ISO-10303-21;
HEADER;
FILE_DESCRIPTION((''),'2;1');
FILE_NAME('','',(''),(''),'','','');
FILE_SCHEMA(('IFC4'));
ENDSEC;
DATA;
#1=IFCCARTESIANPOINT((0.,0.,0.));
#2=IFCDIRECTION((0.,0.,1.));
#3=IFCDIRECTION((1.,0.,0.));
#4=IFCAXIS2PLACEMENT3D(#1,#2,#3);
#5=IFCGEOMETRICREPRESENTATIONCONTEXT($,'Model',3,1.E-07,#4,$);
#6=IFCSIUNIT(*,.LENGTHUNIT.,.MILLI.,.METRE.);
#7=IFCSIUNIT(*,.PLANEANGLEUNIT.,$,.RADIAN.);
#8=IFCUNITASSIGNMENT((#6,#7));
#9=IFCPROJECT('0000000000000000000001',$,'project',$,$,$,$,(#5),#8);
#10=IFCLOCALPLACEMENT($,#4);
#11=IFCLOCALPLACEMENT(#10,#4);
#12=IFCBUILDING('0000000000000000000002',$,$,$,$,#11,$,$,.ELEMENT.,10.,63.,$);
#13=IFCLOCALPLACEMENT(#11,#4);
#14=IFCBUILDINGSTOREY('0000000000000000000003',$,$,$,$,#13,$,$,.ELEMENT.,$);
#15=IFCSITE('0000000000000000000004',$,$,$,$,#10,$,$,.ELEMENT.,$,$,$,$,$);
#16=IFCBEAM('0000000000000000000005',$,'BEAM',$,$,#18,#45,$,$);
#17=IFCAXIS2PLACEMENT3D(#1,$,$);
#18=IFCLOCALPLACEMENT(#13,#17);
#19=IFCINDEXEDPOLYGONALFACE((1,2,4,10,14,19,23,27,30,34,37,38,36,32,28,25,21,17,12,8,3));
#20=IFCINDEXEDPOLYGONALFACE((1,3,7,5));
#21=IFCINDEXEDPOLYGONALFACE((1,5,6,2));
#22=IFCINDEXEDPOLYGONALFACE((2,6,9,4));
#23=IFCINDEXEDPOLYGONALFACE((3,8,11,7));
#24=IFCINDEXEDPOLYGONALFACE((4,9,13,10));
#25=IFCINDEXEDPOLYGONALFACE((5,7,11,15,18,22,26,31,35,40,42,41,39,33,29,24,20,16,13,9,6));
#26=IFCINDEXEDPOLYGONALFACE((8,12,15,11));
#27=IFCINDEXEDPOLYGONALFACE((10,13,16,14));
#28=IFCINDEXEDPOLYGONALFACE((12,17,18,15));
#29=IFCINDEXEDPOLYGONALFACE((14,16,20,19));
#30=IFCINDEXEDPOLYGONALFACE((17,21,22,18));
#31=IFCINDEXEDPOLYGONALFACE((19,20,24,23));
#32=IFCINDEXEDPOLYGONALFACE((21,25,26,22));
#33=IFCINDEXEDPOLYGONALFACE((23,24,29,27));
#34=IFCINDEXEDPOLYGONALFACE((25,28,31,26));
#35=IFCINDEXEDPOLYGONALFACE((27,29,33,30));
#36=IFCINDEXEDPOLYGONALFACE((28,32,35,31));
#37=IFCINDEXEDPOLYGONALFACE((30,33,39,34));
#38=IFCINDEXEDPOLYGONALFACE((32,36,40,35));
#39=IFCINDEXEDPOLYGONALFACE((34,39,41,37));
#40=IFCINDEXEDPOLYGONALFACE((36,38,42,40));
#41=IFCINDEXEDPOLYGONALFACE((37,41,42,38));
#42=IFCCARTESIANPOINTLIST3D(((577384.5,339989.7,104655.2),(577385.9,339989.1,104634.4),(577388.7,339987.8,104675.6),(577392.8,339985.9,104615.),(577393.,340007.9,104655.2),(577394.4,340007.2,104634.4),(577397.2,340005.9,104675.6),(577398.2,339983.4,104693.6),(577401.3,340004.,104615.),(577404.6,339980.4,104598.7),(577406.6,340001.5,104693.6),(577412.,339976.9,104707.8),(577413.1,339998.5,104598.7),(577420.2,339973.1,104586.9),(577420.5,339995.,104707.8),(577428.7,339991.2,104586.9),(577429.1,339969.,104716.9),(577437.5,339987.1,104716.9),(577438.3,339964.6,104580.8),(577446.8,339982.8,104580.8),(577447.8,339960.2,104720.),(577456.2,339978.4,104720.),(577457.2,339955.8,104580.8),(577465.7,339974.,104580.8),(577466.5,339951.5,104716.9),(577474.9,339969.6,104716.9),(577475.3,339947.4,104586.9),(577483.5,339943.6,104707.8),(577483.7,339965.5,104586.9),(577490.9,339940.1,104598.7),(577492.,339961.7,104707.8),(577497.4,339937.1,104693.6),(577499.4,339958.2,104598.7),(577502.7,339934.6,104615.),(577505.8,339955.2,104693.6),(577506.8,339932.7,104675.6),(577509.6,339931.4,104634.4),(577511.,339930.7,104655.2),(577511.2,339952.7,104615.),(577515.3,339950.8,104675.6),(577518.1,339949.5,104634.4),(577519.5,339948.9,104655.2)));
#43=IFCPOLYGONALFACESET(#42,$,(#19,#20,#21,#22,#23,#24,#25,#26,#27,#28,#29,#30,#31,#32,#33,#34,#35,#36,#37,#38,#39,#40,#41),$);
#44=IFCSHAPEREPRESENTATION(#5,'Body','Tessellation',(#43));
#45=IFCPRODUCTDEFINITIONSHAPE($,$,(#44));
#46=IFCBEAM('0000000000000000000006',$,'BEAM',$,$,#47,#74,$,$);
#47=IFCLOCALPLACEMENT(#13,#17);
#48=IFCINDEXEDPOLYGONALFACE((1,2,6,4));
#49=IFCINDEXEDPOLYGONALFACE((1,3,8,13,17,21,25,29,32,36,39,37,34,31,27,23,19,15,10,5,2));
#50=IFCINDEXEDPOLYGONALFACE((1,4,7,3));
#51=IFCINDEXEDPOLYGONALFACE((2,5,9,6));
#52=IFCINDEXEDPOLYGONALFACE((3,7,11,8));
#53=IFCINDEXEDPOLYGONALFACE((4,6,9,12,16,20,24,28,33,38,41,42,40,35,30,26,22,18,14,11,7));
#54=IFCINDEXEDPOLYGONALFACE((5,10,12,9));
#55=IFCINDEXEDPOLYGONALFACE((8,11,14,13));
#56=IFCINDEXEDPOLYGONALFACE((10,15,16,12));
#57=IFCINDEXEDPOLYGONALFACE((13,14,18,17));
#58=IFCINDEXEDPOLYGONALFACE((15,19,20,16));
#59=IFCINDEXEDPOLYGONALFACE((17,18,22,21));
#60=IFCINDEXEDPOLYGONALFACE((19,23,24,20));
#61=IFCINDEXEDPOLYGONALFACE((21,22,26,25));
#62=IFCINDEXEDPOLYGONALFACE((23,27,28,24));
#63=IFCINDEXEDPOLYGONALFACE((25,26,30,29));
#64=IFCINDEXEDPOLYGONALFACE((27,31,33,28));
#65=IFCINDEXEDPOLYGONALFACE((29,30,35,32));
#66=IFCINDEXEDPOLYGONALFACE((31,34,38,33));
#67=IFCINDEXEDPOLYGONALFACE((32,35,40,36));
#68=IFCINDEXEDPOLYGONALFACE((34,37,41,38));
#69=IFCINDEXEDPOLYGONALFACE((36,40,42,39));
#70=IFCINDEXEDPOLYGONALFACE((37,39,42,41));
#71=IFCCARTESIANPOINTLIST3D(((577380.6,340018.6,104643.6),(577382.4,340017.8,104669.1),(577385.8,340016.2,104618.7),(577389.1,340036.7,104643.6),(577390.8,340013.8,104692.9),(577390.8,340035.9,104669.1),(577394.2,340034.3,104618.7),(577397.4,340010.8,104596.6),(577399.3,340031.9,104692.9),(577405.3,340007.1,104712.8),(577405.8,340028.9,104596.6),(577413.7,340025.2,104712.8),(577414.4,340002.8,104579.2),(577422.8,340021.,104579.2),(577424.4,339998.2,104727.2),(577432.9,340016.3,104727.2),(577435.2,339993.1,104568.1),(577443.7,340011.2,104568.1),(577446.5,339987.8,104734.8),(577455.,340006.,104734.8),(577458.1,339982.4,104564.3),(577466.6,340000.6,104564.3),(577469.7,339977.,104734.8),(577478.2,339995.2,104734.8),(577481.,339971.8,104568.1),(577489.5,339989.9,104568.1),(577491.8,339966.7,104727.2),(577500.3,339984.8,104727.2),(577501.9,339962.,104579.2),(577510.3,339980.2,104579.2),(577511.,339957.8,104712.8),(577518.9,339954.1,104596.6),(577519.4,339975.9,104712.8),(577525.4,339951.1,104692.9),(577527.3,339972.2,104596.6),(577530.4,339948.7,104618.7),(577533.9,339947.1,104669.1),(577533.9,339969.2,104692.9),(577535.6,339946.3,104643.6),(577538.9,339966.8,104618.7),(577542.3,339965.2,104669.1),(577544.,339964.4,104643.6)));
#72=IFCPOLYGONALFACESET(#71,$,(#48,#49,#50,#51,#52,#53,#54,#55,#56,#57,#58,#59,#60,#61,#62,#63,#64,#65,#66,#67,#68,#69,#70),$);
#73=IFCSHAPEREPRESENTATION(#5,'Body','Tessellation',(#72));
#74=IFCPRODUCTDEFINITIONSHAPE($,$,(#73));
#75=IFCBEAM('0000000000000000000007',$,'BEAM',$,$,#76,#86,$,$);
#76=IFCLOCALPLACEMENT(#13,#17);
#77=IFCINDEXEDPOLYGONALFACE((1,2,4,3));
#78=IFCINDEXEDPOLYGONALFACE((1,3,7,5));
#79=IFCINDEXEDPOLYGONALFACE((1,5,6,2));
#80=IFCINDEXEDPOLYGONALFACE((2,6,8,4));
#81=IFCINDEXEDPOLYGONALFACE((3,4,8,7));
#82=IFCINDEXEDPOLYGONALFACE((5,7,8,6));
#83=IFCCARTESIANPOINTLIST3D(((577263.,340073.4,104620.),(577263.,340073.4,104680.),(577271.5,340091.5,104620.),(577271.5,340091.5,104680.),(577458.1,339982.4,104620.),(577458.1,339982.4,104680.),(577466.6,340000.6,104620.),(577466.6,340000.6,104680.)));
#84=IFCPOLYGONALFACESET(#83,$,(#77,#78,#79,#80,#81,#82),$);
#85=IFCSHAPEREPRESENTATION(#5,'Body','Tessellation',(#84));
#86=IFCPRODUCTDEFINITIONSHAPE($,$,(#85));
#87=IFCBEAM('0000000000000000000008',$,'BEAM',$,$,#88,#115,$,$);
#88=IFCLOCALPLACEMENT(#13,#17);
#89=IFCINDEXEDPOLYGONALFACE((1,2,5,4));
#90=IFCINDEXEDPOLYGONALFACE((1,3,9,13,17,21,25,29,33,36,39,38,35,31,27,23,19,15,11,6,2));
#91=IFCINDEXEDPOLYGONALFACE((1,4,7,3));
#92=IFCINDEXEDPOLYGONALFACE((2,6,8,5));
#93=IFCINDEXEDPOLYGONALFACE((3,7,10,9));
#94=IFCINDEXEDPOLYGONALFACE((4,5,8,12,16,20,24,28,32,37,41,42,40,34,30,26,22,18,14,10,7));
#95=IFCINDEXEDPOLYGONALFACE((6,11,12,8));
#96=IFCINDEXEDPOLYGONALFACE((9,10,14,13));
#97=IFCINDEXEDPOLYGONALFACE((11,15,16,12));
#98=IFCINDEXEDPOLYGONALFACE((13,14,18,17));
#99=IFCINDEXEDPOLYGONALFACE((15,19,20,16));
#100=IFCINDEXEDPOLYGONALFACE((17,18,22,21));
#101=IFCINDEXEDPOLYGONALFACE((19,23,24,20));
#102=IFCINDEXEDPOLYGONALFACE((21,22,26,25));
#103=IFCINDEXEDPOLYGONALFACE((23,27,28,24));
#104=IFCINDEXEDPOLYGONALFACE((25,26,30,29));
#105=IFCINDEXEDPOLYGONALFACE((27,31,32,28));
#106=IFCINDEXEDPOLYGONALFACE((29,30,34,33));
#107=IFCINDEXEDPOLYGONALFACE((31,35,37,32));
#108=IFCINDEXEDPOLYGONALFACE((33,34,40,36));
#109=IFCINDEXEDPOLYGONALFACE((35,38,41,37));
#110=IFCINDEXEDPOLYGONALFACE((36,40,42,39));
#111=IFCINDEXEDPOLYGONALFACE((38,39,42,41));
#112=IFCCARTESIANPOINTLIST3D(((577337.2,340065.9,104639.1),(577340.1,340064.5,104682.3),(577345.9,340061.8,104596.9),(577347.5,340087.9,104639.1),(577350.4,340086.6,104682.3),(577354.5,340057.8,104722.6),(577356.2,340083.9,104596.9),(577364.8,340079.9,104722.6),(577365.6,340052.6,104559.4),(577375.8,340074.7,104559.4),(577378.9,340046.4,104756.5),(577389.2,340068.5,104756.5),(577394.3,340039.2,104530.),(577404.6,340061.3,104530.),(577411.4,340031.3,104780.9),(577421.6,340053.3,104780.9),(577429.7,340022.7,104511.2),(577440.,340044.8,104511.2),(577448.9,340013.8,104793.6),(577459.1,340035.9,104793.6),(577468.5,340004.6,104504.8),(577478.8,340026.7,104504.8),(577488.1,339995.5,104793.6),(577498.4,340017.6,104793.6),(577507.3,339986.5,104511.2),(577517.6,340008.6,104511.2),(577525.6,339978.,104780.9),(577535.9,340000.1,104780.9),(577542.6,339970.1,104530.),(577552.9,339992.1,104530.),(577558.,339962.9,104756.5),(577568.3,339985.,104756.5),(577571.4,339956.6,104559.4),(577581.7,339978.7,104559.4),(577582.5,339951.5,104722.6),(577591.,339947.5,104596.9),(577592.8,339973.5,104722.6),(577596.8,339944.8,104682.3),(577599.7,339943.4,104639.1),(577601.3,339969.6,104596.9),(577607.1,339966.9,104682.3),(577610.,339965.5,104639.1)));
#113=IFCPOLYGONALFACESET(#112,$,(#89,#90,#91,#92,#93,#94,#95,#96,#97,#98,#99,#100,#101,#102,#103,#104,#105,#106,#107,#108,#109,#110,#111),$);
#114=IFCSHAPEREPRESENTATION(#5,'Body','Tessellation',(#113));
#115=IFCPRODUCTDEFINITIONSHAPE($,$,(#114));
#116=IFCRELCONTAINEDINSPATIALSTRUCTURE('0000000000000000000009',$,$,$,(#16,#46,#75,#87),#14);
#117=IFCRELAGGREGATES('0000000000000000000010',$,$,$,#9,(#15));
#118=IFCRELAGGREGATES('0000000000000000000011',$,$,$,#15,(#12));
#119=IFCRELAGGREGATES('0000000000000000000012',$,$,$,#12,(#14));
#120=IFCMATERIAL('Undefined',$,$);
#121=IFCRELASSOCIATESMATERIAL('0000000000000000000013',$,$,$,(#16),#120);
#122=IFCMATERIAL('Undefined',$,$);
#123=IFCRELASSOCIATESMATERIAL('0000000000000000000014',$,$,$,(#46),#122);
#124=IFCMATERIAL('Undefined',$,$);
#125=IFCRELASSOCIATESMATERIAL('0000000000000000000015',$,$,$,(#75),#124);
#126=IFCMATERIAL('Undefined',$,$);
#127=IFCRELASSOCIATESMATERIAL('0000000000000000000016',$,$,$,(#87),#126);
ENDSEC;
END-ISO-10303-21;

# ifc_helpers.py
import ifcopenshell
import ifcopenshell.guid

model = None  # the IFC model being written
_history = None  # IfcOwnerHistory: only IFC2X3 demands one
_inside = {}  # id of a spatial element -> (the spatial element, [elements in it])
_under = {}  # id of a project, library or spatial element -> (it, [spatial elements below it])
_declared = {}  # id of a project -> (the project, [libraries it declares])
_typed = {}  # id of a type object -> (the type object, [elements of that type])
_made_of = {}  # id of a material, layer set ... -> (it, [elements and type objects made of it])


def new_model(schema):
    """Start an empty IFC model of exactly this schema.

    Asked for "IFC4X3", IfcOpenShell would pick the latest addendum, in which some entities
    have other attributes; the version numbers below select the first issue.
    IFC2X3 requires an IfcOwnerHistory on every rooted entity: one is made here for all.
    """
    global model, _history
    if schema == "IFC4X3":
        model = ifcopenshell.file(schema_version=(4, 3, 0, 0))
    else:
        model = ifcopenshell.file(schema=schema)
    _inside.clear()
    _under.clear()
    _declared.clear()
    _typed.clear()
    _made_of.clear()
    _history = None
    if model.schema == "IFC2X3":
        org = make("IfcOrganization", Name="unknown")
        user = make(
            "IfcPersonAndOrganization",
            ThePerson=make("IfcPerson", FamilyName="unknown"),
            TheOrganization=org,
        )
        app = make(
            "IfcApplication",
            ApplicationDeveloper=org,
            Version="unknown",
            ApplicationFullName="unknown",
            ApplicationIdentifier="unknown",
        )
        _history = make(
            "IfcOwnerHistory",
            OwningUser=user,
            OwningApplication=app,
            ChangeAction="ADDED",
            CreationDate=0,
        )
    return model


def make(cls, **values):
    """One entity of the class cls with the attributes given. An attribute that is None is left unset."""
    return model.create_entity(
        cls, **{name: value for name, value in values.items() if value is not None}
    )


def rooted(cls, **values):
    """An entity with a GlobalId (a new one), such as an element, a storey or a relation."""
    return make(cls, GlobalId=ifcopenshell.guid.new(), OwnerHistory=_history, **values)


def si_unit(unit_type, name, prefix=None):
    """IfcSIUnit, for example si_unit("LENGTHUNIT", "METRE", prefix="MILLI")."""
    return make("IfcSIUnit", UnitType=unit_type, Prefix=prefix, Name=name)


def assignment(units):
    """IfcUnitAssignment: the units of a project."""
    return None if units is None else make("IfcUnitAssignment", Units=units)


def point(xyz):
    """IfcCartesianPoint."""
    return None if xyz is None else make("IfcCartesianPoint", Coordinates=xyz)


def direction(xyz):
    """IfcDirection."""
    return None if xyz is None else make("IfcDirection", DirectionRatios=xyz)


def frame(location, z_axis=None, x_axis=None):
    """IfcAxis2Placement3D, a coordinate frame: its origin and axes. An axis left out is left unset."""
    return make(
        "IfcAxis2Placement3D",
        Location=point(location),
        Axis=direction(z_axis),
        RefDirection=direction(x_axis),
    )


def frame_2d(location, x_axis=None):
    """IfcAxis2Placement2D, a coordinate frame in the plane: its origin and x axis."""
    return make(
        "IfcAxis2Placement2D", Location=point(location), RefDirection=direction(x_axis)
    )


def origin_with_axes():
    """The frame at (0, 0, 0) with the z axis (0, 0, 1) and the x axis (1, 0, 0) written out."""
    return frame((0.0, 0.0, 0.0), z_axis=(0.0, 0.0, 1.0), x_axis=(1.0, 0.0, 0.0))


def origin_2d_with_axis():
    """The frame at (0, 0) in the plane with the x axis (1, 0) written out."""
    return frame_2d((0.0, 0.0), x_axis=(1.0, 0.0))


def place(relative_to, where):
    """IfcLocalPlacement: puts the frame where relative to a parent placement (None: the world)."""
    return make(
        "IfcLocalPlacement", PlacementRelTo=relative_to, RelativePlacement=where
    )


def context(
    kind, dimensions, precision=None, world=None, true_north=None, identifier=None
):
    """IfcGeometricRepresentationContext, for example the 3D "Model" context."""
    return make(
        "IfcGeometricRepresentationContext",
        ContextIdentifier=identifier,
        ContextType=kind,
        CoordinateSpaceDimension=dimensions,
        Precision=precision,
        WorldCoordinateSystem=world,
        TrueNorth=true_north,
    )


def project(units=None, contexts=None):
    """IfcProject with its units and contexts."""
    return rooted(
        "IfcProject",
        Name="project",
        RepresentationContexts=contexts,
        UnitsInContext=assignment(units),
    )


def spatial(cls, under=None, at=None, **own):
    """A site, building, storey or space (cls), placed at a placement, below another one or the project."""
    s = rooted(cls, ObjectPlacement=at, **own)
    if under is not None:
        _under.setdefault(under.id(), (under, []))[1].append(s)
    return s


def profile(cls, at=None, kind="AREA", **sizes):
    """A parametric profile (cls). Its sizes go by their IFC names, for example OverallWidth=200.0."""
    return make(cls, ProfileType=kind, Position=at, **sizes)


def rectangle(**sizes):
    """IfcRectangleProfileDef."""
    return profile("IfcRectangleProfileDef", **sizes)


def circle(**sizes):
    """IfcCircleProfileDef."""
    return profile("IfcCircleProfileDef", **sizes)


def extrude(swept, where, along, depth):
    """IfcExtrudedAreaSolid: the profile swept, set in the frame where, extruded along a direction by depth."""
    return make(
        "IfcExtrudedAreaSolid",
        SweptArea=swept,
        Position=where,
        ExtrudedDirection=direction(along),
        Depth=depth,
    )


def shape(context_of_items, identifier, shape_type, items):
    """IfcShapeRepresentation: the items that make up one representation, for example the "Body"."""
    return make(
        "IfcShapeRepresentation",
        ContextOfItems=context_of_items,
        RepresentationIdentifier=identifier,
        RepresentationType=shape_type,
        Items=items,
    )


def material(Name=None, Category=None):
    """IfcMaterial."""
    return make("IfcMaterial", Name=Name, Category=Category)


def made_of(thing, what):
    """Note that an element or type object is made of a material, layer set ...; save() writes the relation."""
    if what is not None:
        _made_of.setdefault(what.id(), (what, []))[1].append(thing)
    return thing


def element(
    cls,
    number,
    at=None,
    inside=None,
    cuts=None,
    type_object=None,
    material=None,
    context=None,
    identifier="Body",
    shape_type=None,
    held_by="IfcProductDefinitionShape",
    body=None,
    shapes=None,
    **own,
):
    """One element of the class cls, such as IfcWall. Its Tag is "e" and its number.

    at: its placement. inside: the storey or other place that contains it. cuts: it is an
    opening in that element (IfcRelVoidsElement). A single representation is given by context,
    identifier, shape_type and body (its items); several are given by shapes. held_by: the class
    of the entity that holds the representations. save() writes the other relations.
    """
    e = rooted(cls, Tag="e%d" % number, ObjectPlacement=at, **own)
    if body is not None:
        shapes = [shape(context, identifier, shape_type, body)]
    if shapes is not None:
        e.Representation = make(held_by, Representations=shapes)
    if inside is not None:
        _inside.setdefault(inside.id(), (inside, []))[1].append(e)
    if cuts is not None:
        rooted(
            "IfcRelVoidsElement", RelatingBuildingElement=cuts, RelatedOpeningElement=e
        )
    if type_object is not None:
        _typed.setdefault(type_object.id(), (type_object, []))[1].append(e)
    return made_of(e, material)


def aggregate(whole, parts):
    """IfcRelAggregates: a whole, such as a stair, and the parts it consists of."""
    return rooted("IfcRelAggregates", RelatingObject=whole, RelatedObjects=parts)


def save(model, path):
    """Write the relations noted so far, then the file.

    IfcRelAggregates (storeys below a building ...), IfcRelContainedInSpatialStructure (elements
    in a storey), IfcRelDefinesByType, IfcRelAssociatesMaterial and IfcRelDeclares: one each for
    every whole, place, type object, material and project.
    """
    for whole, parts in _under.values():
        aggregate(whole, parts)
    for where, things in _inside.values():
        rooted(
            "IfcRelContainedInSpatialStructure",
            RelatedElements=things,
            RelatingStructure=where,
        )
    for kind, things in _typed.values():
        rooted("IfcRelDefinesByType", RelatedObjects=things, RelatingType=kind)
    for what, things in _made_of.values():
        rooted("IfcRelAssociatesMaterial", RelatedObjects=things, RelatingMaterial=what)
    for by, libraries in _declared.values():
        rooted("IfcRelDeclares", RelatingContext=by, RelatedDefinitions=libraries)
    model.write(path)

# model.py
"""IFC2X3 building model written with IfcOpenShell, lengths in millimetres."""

from ifc_helpers import new_model, si_unit, frame, origin_with_axes, origin_2d_with_axis, place, context, project, spatial, rectangle, circle, extrude, material, element, save


model = new_model("IFC2X3")

# Units and contexts
model_context = context("Model", 3, precision=1e-07, world=origin_with_axes())
ifc_project = project(units=[si_unit("LENGTHUNIT", "METRE", prefix="MILLI"), si_unit("PLANEANGLEUNIT", "RADIAN")], contexts=[model_context])

# Site, building, storey
site_placement = place(None, origin_with_axes())
site = spatial("IfcSite", under=ifc_project, at=site_placement, CompositionType="ELEMENT")
building_placement = place(site_placement, origin_with_axes())
building = spatial("IfcBuilding", under=site, at=building_placement, CompositionType="ELEMENT", ElevationOfRefHeight=10.0, ElevationOfTerrain=63.0)
storey_placement = place(building_placement, origin_with_axes())
storey = spatial("IfcBuildingStorey", under=building, at=storey_placement, CompositionType="ELEMENT")

# Beams
ifc_material_1 = material(Name="Undefined")
beam_1_placement = place(storey_placement, frame((577452.0, 339969.3, 104650.0), z_axis=(-0.422618, -0.906308, 0.0), x_axis=(-0.906308, 0.422618, 0.0)))
element("IfcBeam", 1, at=beam_1_placement, inside=storey, material=ifc_material_1, Name="BEAM", context=model_context, shape_type="SweptSolid", body=[
    extrude(circle(Radius=70.0, at=origin_2d_with_axis()), frame((0.0, 0.0, -10.0), z_axis=(0.0, 0.0, 1.0), x_axis=(0.0, -1.0, 0.0)), (0.0, 0.0, 1.0), 20.0),
])
ifc_material_2 = material(Name="Undefined")
beam_2_placement = place(storey_placement, frame((577462.3, 339991.5, 104650.0), z_axis=(0.422618, 0.906308, 0.0), x_axis=(-0.906308, 0.422618, 0.0)))
element("IfcBeam", 2, at=beam_2_placement, inside=storey, material=ifc_material_2, Name="BEAM", context=model_context, shape_type="SweptSolid", body=[
    extrude(circle(Radius=85.7, at=origin_2d_with_axis()), frame((0.0, 0.0, -10.0), z_axis=(0.0, 0.0, 1.0), x_axis=(0.0, -1.0, 0.0)), (0.0, 0.0, 1.0), 20.0),
])
ifc_material_3 = material(Name="Undefined")
beam_3_placement = place(storey_placement, frame((577364.8, 340037.0, 104650.0), z_axis=(0.0, 0.0, 1.0), x_axis=(-0.906308, 0.422618, 0.0)))
element("IfcBeam", 3, at=beam_3_placement, inside=storey, material=ifc_material_3, Name="BEAM", context=model_context, shape_type="SweptSolid", body=[
    extrude(rectangle(XDim=20.0, YDim=215.2, at=origin_2d_with_axis()), frame((0.0, 0.0, -30.0), z_axis=(0.0, 0.0, 1.0), x_axis=(0.0, -1.0, 0.0)), (0.0, 0.0, 1.0), 60.0),
])
ifc_material_4 = material(Name="Undefined")
beam_4_placement = place(storey_placement, frame((577473.6, 340015.7, 104650.0), z_axis=(0.422618, 0.906308, 0.0), x_axis=(-0.906308, 0.422618, 0.0)))
element("IfcBeam", 4, at=beam_4_placement, inside=storey, material=ifc_material_4, Name="BEAM", context=model_context, shape_type="SweptSolid", body=[
    extrude(circle(Radius=145.2, at=origin_2d_with_axis()), frame((0.0, 0.0, -12.2), z_axis=(0.0, 0.0, 1.0), x_axis=(0.0, -1.0, 0.0)), (0.0, 0.0, 1.0), 24.4),
])

save(model, "model.ifc")
